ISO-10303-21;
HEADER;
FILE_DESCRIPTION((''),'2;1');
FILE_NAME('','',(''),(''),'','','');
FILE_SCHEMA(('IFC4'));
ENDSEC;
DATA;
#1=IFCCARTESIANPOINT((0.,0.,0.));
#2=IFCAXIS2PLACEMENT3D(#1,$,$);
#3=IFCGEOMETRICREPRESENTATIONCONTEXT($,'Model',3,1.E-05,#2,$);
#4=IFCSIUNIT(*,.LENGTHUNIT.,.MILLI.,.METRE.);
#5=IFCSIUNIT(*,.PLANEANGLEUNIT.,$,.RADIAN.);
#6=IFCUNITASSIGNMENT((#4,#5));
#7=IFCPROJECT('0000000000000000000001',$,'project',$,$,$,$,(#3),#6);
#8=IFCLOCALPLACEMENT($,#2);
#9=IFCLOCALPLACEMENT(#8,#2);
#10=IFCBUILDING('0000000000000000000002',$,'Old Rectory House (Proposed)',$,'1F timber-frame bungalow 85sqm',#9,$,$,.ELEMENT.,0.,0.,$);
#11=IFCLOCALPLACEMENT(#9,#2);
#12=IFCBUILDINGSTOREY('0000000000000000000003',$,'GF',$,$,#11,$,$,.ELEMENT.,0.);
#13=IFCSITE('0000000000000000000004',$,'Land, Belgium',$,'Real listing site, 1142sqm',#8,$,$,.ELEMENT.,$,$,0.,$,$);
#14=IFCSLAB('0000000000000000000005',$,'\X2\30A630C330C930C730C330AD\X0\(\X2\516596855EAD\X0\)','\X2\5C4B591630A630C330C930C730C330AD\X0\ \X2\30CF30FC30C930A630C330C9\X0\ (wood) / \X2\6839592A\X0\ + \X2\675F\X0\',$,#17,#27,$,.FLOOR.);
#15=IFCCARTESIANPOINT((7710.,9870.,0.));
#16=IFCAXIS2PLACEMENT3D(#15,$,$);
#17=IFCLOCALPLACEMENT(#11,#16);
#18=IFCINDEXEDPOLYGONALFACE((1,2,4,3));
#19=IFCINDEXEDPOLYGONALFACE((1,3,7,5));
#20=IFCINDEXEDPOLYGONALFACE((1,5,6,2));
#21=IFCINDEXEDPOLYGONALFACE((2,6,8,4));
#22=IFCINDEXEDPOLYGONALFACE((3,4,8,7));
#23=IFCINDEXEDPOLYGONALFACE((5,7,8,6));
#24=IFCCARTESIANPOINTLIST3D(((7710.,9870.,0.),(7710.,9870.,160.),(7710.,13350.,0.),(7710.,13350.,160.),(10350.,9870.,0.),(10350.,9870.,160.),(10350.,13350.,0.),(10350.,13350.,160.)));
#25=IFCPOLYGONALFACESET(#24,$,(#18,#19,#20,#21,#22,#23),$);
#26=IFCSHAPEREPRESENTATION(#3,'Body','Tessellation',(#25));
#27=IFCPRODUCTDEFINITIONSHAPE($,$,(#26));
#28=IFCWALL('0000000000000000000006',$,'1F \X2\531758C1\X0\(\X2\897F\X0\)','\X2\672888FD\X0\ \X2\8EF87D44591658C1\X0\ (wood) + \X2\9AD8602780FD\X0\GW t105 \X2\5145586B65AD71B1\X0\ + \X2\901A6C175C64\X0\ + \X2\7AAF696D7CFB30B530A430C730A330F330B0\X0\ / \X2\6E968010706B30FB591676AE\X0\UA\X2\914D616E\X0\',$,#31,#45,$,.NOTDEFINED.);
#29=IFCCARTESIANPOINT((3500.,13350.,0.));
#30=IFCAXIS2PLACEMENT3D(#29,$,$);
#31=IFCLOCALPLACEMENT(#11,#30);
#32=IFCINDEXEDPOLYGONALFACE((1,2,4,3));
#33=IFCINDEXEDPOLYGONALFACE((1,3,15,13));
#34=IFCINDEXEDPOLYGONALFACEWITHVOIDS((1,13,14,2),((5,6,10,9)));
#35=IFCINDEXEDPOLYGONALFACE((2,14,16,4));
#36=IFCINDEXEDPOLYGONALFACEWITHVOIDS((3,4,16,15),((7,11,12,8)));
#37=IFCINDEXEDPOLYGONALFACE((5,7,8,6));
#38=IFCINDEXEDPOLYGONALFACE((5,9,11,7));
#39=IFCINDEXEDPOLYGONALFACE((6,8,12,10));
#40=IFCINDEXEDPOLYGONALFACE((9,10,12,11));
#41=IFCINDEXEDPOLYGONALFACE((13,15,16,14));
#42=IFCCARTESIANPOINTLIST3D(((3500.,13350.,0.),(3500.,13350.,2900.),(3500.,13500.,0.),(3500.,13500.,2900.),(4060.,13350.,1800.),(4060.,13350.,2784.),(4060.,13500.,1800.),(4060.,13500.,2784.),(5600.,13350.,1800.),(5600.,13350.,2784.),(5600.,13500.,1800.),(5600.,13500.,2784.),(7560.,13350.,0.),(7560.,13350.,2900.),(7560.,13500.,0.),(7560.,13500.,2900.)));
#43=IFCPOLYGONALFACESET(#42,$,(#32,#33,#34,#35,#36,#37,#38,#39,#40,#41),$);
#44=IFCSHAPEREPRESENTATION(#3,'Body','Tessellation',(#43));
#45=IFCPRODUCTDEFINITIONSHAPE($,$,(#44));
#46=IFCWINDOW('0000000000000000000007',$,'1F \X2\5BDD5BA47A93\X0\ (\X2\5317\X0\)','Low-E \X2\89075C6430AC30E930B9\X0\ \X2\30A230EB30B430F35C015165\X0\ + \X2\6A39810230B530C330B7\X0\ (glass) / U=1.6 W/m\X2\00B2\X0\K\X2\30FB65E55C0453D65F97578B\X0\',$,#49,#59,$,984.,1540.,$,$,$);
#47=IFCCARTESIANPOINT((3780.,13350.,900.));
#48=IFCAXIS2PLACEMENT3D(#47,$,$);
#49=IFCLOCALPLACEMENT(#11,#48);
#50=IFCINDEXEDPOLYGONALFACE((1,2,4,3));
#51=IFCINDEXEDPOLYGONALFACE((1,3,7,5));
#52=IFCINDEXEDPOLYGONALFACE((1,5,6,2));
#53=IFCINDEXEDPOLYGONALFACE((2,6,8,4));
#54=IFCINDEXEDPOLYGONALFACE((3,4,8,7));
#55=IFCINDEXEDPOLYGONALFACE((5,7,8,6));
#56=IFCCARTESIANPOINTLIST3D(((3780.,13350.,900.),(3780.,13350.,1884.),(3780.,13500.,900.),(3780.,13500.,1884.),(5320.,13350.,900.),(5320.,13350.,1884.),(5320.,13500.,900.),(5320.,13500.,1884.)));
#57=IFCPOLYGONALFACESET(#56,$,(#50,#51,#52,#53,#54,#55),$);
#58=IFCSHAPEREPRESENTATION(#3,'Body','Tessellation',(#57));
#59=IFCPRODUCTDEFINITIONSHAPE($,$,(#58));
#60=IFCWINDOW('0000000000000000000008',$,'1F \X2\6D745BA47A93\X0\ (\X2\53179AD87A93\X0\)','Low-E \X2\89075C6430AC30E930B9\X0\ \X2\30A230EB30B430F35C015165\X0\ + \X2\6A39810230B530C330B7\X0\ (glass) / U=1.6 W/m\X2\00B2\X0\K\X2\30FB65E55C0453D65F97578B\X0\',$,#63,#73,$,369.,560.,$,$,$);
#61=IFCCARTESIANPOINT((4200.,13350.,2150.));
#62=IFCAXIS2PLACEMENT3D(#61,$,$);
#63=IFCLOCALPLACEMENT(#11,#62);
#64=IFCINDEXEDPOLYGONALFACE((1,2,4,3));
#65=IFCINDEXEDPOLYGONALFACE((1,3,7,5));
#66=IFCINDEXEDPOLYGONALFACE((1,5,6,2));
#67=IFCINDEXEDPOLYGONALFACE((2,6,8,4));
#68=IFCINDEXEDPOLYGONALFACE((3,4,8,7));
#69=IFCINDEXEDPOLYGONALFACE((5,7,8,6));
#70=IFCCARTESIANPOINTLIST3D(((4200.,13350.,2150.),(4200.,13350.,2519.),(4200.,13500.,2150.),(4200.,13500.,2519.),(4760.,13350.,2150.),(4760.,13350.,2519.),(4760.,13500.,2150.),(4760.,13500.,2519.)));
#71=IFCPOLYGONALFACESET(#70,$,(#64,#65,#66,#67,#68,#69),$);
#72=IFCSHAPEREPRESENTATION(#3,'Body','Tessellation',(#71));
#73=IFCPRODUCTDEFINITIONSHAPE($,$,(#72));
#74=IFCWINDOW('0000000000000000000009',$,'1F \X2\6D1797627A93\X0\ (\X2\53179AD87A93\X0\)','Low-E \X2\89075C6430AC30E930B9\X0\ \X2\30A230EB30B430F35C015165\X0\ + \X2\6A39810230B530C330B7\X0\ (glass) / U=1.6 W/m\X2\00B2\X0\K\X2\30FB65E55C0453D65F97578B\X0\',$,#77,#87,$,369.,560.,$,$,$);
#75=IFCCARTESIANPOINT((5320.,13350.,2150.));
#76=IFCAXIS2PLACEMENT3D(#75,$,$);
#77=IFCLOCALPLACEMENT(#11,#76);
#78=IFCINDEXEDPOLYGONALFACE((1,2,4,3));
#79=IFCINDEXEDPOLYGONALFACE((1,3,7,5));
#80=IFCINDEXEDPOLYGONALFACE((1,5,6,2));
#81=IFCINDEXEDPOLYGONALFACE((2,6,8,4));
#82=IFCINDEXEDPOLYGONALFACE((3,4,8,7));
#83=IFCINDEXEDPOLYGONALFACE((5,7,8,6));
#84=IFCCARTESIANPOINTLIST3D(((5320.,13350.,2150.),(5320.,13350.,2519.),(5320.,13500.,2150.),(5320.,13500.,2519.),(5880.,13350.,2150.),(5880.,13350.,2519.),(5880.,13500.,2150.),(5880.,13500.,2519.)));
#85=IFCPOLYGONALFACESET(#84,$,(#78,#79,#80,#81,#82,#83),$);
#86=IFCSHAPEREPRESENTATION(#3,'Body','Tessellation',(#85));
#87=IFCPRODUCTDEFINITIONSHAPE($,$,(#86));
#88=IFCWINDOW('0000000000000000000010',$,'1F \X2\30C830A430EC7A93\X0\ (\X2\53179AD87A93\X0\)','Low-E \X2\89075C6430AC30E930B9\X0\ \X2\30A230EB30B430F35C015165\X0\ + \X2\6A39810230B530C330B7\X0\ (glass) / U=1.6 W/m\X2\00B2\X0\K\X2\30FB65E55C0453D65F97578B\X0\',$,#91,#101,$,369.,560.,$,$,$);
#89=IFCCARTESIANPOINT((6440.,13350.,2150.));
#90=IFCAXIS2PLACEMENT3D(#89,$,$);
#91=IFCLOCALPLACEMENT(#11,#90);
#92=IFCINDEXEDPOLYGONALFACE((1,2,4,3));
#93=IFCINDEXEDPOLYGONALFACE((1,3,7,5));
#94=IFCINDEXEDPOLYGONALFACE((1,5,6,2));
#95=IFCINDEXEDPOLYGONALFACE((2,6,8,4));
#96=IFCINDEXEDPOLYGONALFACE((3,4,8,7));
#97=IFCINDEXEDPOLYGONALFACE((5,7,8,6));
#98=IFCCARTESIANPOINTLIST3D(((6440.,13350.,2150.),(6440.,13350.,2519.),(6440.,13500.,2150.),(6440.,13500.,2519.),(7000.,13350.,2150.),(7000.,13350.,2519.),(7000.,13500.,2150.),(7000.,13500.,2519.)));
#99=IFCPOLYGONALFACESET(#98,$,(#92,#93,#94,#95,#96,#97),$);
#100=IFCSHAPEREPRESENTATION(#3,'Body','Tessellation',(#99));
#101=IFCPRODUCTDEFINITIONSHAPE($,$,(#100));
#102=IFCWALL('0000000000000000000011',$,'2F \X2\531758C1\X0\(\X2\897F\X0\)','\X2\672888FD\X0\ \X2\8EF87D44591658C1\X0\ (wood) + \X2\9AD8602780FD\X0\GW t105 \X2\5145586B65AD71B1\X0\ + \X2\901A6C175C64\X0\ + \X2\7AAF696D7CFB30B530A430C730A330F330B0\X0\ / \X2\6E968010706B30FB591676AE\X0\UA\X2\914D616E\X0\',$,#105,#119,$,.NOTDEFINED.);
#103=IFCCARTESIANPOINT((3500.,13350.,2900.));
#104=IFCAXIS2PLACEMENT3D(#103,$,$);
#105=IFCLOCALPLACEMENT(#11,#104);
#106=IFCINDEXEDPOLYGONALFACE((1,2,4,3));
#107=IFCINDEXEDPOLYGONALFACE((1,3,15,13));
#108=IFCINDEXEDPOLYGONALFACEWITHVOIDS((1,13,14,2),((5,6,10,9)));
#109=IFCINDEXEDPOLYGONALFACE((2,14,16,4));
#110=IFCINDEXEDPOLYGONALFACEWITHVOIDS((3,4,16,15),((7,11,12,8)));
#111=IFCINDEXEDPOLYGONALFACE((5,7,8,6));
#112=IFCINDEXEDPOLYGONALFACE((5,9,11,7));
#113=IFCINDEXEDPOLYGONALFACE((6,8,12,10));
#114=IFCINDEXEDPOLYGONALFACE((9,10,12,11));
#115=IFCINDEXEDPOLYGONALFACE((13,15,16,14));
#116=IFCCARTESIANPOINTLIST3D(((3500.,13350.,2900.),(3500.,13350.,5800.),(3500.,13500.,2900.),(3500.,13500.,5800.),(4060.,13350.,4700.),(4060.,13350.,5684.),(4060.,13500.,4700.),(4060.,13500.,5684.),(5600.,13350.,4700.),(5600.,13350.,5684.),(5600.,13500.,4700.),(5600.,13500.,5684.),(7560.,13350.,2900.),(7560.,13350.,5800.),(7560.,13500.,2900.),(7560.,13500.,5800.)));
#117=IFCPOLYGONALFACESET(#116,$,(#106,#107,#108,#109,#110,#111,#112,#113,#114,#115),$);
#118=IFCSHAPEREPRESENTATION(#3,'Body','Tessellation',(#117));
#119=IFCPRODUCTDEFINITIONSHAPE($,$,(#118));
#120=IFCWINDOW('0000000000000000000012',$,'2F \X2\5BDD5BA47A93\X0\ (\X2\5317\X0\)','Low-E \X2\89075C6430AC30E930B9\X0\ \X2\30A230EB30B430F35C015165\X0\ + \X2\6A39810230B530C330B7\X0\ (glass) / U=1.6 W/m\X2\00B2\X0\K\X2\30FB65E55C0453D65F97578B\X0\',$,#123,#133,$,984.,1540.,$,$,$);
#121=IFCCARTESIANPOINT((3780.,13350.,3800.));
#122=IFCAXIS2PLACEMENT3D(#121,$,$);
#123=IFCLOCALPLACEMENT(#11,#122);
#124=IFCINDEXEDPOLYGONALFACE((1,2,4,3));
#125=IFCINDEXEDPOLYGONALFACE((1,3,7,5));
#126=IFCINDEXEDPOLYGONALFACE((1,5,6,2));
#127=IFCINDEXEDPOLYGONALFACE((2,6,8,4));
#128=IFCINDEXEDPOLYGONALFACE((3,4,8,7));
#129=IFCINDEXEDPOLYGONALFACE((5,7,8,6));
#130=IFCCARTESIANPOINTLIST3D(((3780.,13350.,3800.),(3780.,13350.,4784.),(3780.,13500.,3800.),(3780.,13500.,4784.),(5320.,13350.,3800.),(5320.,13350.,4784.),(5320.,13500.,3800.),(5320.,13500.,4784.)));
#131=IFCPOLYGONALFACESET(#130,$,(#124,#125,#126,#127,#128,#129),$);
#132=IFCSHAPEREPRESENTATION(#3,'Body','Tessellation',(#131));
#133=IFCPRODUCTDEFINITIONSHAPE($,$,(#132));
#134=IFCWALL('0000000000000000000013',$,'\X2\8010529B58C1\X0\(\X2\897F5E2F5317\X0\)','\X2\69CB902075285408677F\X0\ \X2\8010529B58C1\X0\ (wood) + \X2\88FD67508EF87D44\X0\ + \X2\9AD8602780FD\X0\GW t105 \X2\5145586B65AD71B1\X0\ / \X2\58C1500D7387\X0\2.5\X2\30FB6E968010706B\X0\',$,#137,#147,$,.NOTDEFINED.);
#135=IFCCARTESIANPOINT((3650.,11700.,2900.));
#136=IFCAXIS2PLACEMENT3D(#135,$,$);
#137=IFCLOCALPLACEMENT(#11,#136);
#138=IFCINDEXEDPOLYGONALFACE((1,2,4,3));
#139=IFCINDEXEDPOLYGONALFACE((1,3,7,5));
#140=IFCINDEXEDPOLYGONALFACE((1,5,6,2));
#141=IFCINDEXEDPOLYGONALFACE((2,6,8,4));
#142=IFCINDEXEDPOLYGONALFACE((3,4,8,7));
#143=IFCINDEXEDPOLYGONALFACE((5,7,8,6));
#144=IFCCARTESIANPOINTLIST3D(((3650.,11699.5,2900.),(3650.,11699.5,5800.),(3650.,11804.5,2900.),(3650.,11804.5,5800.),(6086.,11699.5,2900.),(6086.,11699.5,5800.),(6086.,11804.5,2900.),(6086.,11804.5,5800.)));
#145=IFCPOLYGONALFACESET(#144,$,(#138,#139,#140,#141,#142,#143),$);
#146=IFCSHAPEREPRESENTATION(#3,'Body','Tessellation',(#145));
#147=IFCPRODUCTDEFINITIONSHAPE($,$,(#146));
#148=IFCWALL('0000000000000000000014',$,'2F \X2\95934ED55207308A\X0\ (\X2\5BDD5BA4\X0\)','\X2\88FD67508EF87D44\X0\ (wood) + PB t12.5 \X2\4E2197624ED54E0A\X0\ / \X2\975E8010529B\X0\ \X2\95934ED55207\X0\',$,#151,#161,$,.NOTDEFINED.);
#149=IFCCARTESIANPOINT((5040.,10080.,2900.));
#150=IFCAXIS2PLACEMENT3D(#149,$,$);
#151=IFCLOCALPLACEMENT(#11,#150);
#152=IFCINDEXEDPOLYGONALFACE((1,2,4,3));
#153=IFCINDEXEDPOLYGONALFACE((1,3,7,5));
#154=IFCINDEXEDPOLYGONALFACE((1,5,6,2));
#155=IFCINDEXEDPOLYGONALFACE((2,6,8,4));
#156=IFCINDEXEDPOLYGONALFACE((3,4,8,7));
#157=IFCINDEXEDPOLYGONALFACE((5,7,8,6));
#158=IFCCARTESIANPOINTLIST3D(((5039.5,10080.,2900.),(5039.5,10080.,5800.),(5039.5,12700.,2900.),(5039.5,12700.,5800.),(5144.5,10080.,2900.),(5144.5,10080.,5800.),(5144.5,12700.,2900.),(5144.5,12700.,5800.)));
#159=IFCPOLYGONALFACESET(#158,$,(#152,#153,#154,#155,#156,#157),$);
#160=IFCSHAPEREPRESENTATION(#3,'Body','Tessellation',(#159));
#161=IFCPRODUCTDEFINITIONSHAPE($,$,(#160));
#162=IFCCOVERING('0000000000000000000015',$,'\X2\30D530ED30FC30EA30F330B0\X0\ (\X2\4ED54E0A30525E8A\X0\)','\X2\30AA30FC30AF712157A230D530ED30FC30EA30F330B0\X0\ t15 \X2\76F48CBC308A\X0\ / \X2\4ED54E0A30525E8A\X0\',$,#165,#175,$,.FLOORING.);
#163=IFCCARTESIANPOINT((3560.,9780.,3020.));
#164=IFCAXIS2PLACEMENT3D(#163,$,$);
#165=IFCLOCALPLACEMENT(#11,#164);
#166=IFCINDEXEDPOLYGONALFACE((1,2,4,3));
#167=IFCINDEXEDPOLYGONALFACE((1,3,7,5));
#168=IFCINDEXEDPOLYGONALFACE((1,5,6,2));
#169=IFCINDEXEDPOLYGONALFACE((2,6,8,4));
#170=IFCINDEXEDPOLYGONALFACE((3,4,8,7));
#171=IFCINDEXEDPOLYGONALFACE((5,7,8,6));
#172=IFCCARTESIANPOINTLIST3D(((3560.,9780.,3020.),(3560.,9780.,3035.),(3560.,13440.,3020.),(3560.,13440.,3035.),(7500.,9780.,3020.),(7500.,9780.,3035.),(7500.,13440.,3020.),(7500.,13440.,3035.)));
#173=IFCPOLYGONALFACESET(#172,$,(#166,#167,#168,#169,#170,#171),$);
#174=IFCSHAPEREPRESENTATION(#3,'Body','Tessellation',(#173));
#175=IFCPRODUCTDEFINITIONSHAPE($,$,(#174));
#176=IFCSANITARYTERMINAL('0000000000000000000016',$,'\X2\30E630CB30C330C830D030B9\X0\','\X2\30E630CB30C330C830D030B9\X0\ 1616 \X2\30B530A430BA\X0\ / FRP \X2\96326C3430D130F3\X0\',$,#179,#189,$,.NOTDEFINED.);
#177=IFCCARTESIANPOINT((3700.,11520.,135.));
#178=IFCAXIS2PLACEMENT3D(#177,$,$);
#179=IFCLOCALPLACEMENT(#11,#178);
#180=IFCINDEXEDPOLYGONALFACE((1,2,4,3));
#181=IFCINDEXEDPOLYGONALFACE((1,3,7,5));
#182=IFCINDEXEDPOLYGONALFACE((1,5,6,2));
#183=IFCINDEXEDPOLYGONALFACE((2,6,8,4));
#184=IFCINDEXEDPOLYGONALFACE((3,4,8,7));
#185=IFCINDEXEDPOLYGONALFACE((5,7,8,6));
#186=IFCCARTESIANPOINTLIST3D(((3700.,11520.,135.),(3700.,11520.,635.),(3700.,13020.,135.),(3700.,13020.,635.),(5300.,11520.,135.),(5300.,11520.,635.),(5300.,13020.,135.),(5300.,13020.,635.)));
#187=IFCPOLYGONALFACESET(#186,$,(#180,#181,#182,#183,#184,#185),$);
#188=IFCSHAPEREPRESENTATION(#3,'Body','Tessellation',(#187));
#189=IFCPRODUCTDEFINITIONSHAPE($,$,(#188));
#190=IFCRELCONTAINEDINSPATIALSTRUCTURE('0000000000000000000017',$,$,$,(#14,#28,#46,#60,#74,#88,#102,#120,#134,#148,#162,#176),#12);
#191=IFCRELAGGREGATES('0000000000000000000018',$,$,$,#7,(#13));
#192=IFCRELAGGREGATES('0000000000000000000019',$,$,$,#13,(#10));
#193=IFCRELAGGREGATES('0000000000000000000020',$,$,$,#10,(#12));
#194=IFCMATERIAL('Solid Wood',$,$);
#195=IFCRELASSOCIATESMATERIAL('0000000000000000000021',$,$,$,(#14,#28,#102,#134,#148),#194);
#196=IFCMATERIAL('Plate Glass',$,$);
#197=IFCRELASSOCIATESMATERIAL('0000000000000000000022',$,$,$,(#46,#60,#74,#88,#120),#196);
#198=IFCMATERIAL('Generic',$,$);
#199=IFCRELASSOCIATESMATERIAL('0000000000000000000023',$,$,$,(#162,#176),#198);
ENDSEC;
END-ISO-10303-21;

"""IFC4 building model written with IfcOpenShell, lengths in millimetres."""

from ifc_helpers import new_model, si_unit, frame, frame_2d, origin, place, context, project, spatial, rectangle, extrude, material, element, fill, save


model = new_model("IFC4")

# Units and contexts
model_context = context("Model", 3, precision=1e-05, world=origin())
ifc_project = project(units=[si_unit("LENGTHUNIT", "METRE", prefix="MILLI"), si_unit("PLANEANGLEUNIT", "RADIAN")], contexts=[model_context])

# Site, building, storey
site_placement = place(None, origin())
site = spatial("IfcSite", under=ifc_project, at=site_placement, Name="Land, Belgium", ObjectType="Real listing site, 1142sqm", CompositionType="ELEMENT", RefElevation=0.0)
building_placement = place(site_placement, origin())
building = spatial("IfcBuilding", under=site, at=building_placement, Name="Old Rectory House (Proposed)", ObjectType="1F timber-frame bungalow 85sqm", CompositionType="ELEMENT", ElevationOfRefHeight=0.0, ElevationOfTerrain=0.0)
storey_placement = place(building_placement, origin())
storey = spatial("IfcBuildingStorey", under=building, at=storey_placement, Name="GF", CompositionType="ELEMENT", Elevation=0.0)

# Slab
ifc_material_1 = material(Name="Solid Wood")
slab_placement = place(storey_placement, frame((7710.0, 9870.0, 0.0)))
element("IfcSlab", 1, at=slab_placement, inside=storey, material=ifc_material_1, Name="ウッドデッキ(入隅庭)", Description="屋外ウッドデッキ ハードウッド (wood) / 根太 + 束", PredefinedType="FLOOR", context=model_context, shape_type="SweptSolid", body=[
    extrude(rectangle(XDim=2640.0, YDim=3480.0, at=frame_2d((1320.0, 1740.0))), frame((7710.0, 9870.0, 0.0)), (0.0, 0.0, 1.0), 160.0),
])

# Wall, openings, windows
wall_1_placement = place(storey_placement, frame((3500.0, 13350.0, 0.0)))
wall_1 = element("IfcWall", 2, at=wall_1_placement, inside=storey, material=ifc_material_1, Name="1F 北壁(西)", Description="木製 軸組外壁 (wood) + 高性能GW t105 充填断熱 + 通気層 + 窯業系サイディング / 準耐火・外皮UA配慮", PredefinedType="NOTDEFINED", context=model_context, shape_type="SweptSolid", body=[
    extrude(rectangle(XDim=4060.0, YDim=150.0, at=frame_2d((2030.0, 75.0))), frame((3500.0, 13350.0, 0.0)), (0.0, 0.0, 1.0), 2900.0),
])
opening_1_placement = place(storey_placement, frame((3780.0, 13350.0, 900.0)))
opening_1 = element("IfcOpeningElement", 3, at=opening_1_placement, cuts=wall_1, PredefinedType="NOTDEFINED", context=model_context, shape_type="SweptSolid", body=[
    extrude(rectangle(XDim=1540.0, YDim=150.0, at=frame_2d((770.0, 75.0))), frame((3780.0, 13350.0, 900.0)), (0.0, 0.0, 1.0), 984.0),
])
opening_2_placement = place(storey_placement, frame((4200.0, 13350.0, 2150.0)))
opening_2 = element("IfcOpeningElement", 4, at=opening_2_placement, cuts=wall_1, PredefinedType="NOTDEFINED", context=model_context, shape_type="SweptSolid", body=[
    extrude(rectangle(XDim=560.0, YDim=150.0, at=frame_2d((280.0, 75.0))), frame((4200.0, 13350.0, 2150.0)), (0.0, 0.0, 1.0), 369.0),
])
opening_3_placement = place(storey_placement, frame((5320.0, 13350.0, 2150.0)))
opening_3 = element("IfcOpeningElement", 5, at=opening_3_placement, cuts=wall_1, PredefinedType="NOTDEFINED", context=model_context, shape_type="SweptSolid", body=[
    extrude(rectangle(XDim=560.0, YDim=150.0, at=frame_2d((280.0, 75.0))), frame((5320.0, 13350.0, 2150.0)), (0.0, 0.0, 1.0), 369.0),
])
opening_4_placement = place(storey_placement, frame((6440.0, 13350.0, 2150.0)))
opening_4 = element("IfcOpeningElement", 6, at=opening_4_placement, cuts=wall_1, PredefinedType="NOTDEFINED", context=model_context, shape_type="SweptSolid", body=[
    extrude(rectangle(XDim=560.0, YDim=150.0, at=frame_2d((280.0, 75.0))), frame((6440.0, 13350.0, 2150.0)), (0.0, 0.0, 1.0), 369.0),
])
ifc_material_2 = material(Name="Plate Glass")
window_1_placement = place(storey_placement, frame((3780.0, 13350.0, 900.0)))
window_1 = element("IfcWindow", 7, at=window_1_placement, inside=storey, material=ifc_material_2, Name="1F 寝室窓 (北)", Description="Low-E 複層ガラス アルゴン封入 + 樹脂サッシ (glass) / U=1.6 W/m²K・日射取得型", OverallHeight=984.0, OverallWidth=1540.0, context=model_context, shape_type="SweptSolid", body=[
    extrude(rectangle(XDim=1540.0, YDim=150.0, at=frame_2d((770.0, 75.0))), frame((3780.0, 13350.0, 900.0)), (0.0, 0.0, 1.0), 984.0),
])
fill(opening_1, window_1)
window_2_placement = place(storey_placement, frame((4200.0, 13350.0, 2150.0)))
window_2 = element("IfcWindow", 8, at=window_2_placement, inside=storey, material=ifc_material_2, Name="1F 浴室窓 (北高窓)", Description="Low-E 複層ガラス アルゴン封入 + 樹脂サッシ (glass) / U=1.6 W/m²K・日射取得型", OverallHeight=369.0, OverallWidth=560.0, context=model_context, shape_type="SweptSolid", body=[
    extrude(rectangle(XDim=560.0, YDim=150.0, at=frame_2d((280.0, 75.0))), frame((4200.0, 13350.0, 2150.0)), (0.0, 0.0, 1.0), 369.0),
])
fill(opening_2, window_2)
window_3_placement = place(storey_placement, frame((5320.0, 13350.0, 2150.0)))
window_3 = element("IfcWindow", 9, at=window_3_placement, inside=storey, material=ifc_material_2, Name="1F 洗面窓 (北高窓)", Description="Low-E 複層ガラス アルゴン封入 + 樹脂サッシ (glass) / U=1.6 W/m²K・日射取得型", OverallHeight=369.0, OverallWidth=560.0, context=model_context, shape_type="SweptSolid", body=[
    extrude(rectangle(XDim=560.0, YDim=150.0, at=frame_2d((280.0, 75.0))), frame((5320.0, 13350.0, 2150.0)), (0.0, 0.0, 1.0), 369.0),
])
fill(opening_3, window_3)
window_4_placement = place(storey_placement, frame((6440.0, 13350.0, 2150.0)))
window_4 = element("IfcWindow", 10, at=window_4_placement, inside=storey, material=ifc_material_2, Name="1F トイレ窓 (北高窓)", Description="Low-E 複層ガラス アルゴン封入 + 樹脂サッシ (glass) / U=1.6 W/m²K・日射取得型", OverallHeight=369.0, OverallWidth=560.0, context=model_context, shape_type="SweptSolid", body=[
    extrude(rectangle(XDim=560.0, YDim=150.0, at=frame_2d((280.0, 75.0))), frame((6440.0, 13350.0, 2150.0)), (0.0, 0.0, 1.0), 369.0),
])
fill(opening_4, window_4)

# Wall, opening, window
wall_2_placement = place(storey_placement, frame((3500.0, 13350.0, 2900.0)))
wall_2 = element("IfcWall", 11, at=wall_2_placement, inside=storey, material=ifc_material_1, Name="2F 北壁(西)", Description="木製 軸組外壁 (wood) + 高性能GW t105 充填断熱 + 通気層 + 窯業系サイディング / 準耐火・外皮UA配慮", PredefinedType="NOTDEFINED", context=model_context, shape_type="SweptSolid", body=[
    extrude(rectangle(XDim=4060.0, YDim=150.0, at=frame_2d((2030.0, 75.0))), frame((3500.0, 13350.0, 2900.0)), (0.0, 0.0, 1.0), 2900.0),
])
opening_5_placement = place(storey_placement, frame((3780.0, 13350.0, 3800.0)))
opening_5 = element("IfcOpeningElement", 12, at=opening_5_placement, cuts=wall_2, PredefinedType="NOTDEFINED", context=model_context, shape_type="SweptSolid", body=[
    extrude(rectangle(XDim=1540.0, YDim=150.0, at=frame_2d((770.0, 75.0))), frame((3780.0, 13350.0, 3800.0)), (0.0, 0.0, 1.0), 984.0),
])
window_5_placement = place(storey_placement, frame((3780.0, 13350.0, 3800.0)))
window_5 = element("IfcWindow", 13, at=window_5_placement, inside=storey, material=ifc_material_2, Name="2F 寝室窓 (北)", Description="Low-E 複層ガラス アルゴン封入 + 樹脂サッシ (glass) / U=1.6 W/m²K・日射取得型", OverallHeight=984.0, OverallWidth=1540.0, context=model_context, shape_type="SweptSolid", body=[
    extrude(rectangle(XDim=1540.0, YDim=150.0, at=frame_2d((770.0, 75.0))), frame((3780.0, 13350.0, 3800.0)), (0.0, 0.0, 1.0), 984.0),
])
fill(opening_5, window_5)

# Walls
wall_3_placement = place(storey_placement, frame((3650.0, 11700.0, 2900.0)))
element("IfcWall", 14, at=wall_3_placement, inside=storey, material=ifc_material_1, Name="耐力壁(西帯北)", Description="構造用合板 耐力壁 (wood) + 製材軸組 + 高性能GW t105 充填断熱 / 壁倍率2.5・準耐火", PredefinedType="NOTDEFINED", context=model_context, shape_type="SweptSolid", body=[
    extrude(rectangle(XDim=2436.0, YDim=105.0, at=frame_2d((1218.0, 52.0))), frame((3650.0, 11700.0, 2900.0)), (0.0, 0.0, 1.0), 2900.0),
])
wall_4_placement = place(storey_placement, frame((5040.0, 10080.0, 2900.0)))
element("IfcWall", 15, at=wall_4_placement, inside=storey, material=ifc_material_1, Name="2F 間仕切り (寝室)", Description="製材軸組 (wood) + PB t12.5 両面仕上 / 非耐力 間仕切", PredefinedType="NOTDEFINED", context=model_context, shape_type="SweptSolid", body=[
    extrude(rectangle(XDim=105.0, YDim=2620.0, at=frame_2d((52.0, 1310.0))), frame((5040.0, 10080.0, 2900.0)), (0.0, 0.0, 1.0), 2900.0),
])

# Covering
ifc_material_3 = material(Name="Generic")
covering_placement = place(storey_placement, frame((3560.0, 9780.0, 3020.0)))
element("IfcCovering", 16, at=covering_placement, inside=storey, material=ifc_material_3, Name="フローリング (仕上げ床)", Description="オーク無垢フローリング t15 直貼り / 仕上げ床", PredefinedType="FLOORING", context=model_context, shape_type="SweptSolid", body=[
    extrude(rectangle(XDim=3940.0, YDim=3660.0, at=frame_2d((1970.0, 1830.0))), frame((3560.0, 9780.0, 3020.0)), (0.0, 0.0, 1.0), 15.0),
])

# Sanitary terminal
sanitary_terminal_1_placement = place(storey_placement, frame((3700.0, 11520.0, 135.0)))
element("IfcSanitaryTerminal", 17, at=sanitary_terminal_1_placement, inside=storey, material=ifc_material_3, Name="ユニットバス", Description="ユニットバス 1616 サイズ / FRP 防水パン", PredefinedType="NOTDEFINED", context=model_context, shape_type="SweptSolid", body=[
    extrude(rectangle(XDim=1600.0, YDim=1500.0, at=frame_2d((800.0, 750.0))), frame((3700.0, 11520.0, 135.0)), (0.0, 0.0, 1.0), 500.0),
])

save(model, "model.ifc")
